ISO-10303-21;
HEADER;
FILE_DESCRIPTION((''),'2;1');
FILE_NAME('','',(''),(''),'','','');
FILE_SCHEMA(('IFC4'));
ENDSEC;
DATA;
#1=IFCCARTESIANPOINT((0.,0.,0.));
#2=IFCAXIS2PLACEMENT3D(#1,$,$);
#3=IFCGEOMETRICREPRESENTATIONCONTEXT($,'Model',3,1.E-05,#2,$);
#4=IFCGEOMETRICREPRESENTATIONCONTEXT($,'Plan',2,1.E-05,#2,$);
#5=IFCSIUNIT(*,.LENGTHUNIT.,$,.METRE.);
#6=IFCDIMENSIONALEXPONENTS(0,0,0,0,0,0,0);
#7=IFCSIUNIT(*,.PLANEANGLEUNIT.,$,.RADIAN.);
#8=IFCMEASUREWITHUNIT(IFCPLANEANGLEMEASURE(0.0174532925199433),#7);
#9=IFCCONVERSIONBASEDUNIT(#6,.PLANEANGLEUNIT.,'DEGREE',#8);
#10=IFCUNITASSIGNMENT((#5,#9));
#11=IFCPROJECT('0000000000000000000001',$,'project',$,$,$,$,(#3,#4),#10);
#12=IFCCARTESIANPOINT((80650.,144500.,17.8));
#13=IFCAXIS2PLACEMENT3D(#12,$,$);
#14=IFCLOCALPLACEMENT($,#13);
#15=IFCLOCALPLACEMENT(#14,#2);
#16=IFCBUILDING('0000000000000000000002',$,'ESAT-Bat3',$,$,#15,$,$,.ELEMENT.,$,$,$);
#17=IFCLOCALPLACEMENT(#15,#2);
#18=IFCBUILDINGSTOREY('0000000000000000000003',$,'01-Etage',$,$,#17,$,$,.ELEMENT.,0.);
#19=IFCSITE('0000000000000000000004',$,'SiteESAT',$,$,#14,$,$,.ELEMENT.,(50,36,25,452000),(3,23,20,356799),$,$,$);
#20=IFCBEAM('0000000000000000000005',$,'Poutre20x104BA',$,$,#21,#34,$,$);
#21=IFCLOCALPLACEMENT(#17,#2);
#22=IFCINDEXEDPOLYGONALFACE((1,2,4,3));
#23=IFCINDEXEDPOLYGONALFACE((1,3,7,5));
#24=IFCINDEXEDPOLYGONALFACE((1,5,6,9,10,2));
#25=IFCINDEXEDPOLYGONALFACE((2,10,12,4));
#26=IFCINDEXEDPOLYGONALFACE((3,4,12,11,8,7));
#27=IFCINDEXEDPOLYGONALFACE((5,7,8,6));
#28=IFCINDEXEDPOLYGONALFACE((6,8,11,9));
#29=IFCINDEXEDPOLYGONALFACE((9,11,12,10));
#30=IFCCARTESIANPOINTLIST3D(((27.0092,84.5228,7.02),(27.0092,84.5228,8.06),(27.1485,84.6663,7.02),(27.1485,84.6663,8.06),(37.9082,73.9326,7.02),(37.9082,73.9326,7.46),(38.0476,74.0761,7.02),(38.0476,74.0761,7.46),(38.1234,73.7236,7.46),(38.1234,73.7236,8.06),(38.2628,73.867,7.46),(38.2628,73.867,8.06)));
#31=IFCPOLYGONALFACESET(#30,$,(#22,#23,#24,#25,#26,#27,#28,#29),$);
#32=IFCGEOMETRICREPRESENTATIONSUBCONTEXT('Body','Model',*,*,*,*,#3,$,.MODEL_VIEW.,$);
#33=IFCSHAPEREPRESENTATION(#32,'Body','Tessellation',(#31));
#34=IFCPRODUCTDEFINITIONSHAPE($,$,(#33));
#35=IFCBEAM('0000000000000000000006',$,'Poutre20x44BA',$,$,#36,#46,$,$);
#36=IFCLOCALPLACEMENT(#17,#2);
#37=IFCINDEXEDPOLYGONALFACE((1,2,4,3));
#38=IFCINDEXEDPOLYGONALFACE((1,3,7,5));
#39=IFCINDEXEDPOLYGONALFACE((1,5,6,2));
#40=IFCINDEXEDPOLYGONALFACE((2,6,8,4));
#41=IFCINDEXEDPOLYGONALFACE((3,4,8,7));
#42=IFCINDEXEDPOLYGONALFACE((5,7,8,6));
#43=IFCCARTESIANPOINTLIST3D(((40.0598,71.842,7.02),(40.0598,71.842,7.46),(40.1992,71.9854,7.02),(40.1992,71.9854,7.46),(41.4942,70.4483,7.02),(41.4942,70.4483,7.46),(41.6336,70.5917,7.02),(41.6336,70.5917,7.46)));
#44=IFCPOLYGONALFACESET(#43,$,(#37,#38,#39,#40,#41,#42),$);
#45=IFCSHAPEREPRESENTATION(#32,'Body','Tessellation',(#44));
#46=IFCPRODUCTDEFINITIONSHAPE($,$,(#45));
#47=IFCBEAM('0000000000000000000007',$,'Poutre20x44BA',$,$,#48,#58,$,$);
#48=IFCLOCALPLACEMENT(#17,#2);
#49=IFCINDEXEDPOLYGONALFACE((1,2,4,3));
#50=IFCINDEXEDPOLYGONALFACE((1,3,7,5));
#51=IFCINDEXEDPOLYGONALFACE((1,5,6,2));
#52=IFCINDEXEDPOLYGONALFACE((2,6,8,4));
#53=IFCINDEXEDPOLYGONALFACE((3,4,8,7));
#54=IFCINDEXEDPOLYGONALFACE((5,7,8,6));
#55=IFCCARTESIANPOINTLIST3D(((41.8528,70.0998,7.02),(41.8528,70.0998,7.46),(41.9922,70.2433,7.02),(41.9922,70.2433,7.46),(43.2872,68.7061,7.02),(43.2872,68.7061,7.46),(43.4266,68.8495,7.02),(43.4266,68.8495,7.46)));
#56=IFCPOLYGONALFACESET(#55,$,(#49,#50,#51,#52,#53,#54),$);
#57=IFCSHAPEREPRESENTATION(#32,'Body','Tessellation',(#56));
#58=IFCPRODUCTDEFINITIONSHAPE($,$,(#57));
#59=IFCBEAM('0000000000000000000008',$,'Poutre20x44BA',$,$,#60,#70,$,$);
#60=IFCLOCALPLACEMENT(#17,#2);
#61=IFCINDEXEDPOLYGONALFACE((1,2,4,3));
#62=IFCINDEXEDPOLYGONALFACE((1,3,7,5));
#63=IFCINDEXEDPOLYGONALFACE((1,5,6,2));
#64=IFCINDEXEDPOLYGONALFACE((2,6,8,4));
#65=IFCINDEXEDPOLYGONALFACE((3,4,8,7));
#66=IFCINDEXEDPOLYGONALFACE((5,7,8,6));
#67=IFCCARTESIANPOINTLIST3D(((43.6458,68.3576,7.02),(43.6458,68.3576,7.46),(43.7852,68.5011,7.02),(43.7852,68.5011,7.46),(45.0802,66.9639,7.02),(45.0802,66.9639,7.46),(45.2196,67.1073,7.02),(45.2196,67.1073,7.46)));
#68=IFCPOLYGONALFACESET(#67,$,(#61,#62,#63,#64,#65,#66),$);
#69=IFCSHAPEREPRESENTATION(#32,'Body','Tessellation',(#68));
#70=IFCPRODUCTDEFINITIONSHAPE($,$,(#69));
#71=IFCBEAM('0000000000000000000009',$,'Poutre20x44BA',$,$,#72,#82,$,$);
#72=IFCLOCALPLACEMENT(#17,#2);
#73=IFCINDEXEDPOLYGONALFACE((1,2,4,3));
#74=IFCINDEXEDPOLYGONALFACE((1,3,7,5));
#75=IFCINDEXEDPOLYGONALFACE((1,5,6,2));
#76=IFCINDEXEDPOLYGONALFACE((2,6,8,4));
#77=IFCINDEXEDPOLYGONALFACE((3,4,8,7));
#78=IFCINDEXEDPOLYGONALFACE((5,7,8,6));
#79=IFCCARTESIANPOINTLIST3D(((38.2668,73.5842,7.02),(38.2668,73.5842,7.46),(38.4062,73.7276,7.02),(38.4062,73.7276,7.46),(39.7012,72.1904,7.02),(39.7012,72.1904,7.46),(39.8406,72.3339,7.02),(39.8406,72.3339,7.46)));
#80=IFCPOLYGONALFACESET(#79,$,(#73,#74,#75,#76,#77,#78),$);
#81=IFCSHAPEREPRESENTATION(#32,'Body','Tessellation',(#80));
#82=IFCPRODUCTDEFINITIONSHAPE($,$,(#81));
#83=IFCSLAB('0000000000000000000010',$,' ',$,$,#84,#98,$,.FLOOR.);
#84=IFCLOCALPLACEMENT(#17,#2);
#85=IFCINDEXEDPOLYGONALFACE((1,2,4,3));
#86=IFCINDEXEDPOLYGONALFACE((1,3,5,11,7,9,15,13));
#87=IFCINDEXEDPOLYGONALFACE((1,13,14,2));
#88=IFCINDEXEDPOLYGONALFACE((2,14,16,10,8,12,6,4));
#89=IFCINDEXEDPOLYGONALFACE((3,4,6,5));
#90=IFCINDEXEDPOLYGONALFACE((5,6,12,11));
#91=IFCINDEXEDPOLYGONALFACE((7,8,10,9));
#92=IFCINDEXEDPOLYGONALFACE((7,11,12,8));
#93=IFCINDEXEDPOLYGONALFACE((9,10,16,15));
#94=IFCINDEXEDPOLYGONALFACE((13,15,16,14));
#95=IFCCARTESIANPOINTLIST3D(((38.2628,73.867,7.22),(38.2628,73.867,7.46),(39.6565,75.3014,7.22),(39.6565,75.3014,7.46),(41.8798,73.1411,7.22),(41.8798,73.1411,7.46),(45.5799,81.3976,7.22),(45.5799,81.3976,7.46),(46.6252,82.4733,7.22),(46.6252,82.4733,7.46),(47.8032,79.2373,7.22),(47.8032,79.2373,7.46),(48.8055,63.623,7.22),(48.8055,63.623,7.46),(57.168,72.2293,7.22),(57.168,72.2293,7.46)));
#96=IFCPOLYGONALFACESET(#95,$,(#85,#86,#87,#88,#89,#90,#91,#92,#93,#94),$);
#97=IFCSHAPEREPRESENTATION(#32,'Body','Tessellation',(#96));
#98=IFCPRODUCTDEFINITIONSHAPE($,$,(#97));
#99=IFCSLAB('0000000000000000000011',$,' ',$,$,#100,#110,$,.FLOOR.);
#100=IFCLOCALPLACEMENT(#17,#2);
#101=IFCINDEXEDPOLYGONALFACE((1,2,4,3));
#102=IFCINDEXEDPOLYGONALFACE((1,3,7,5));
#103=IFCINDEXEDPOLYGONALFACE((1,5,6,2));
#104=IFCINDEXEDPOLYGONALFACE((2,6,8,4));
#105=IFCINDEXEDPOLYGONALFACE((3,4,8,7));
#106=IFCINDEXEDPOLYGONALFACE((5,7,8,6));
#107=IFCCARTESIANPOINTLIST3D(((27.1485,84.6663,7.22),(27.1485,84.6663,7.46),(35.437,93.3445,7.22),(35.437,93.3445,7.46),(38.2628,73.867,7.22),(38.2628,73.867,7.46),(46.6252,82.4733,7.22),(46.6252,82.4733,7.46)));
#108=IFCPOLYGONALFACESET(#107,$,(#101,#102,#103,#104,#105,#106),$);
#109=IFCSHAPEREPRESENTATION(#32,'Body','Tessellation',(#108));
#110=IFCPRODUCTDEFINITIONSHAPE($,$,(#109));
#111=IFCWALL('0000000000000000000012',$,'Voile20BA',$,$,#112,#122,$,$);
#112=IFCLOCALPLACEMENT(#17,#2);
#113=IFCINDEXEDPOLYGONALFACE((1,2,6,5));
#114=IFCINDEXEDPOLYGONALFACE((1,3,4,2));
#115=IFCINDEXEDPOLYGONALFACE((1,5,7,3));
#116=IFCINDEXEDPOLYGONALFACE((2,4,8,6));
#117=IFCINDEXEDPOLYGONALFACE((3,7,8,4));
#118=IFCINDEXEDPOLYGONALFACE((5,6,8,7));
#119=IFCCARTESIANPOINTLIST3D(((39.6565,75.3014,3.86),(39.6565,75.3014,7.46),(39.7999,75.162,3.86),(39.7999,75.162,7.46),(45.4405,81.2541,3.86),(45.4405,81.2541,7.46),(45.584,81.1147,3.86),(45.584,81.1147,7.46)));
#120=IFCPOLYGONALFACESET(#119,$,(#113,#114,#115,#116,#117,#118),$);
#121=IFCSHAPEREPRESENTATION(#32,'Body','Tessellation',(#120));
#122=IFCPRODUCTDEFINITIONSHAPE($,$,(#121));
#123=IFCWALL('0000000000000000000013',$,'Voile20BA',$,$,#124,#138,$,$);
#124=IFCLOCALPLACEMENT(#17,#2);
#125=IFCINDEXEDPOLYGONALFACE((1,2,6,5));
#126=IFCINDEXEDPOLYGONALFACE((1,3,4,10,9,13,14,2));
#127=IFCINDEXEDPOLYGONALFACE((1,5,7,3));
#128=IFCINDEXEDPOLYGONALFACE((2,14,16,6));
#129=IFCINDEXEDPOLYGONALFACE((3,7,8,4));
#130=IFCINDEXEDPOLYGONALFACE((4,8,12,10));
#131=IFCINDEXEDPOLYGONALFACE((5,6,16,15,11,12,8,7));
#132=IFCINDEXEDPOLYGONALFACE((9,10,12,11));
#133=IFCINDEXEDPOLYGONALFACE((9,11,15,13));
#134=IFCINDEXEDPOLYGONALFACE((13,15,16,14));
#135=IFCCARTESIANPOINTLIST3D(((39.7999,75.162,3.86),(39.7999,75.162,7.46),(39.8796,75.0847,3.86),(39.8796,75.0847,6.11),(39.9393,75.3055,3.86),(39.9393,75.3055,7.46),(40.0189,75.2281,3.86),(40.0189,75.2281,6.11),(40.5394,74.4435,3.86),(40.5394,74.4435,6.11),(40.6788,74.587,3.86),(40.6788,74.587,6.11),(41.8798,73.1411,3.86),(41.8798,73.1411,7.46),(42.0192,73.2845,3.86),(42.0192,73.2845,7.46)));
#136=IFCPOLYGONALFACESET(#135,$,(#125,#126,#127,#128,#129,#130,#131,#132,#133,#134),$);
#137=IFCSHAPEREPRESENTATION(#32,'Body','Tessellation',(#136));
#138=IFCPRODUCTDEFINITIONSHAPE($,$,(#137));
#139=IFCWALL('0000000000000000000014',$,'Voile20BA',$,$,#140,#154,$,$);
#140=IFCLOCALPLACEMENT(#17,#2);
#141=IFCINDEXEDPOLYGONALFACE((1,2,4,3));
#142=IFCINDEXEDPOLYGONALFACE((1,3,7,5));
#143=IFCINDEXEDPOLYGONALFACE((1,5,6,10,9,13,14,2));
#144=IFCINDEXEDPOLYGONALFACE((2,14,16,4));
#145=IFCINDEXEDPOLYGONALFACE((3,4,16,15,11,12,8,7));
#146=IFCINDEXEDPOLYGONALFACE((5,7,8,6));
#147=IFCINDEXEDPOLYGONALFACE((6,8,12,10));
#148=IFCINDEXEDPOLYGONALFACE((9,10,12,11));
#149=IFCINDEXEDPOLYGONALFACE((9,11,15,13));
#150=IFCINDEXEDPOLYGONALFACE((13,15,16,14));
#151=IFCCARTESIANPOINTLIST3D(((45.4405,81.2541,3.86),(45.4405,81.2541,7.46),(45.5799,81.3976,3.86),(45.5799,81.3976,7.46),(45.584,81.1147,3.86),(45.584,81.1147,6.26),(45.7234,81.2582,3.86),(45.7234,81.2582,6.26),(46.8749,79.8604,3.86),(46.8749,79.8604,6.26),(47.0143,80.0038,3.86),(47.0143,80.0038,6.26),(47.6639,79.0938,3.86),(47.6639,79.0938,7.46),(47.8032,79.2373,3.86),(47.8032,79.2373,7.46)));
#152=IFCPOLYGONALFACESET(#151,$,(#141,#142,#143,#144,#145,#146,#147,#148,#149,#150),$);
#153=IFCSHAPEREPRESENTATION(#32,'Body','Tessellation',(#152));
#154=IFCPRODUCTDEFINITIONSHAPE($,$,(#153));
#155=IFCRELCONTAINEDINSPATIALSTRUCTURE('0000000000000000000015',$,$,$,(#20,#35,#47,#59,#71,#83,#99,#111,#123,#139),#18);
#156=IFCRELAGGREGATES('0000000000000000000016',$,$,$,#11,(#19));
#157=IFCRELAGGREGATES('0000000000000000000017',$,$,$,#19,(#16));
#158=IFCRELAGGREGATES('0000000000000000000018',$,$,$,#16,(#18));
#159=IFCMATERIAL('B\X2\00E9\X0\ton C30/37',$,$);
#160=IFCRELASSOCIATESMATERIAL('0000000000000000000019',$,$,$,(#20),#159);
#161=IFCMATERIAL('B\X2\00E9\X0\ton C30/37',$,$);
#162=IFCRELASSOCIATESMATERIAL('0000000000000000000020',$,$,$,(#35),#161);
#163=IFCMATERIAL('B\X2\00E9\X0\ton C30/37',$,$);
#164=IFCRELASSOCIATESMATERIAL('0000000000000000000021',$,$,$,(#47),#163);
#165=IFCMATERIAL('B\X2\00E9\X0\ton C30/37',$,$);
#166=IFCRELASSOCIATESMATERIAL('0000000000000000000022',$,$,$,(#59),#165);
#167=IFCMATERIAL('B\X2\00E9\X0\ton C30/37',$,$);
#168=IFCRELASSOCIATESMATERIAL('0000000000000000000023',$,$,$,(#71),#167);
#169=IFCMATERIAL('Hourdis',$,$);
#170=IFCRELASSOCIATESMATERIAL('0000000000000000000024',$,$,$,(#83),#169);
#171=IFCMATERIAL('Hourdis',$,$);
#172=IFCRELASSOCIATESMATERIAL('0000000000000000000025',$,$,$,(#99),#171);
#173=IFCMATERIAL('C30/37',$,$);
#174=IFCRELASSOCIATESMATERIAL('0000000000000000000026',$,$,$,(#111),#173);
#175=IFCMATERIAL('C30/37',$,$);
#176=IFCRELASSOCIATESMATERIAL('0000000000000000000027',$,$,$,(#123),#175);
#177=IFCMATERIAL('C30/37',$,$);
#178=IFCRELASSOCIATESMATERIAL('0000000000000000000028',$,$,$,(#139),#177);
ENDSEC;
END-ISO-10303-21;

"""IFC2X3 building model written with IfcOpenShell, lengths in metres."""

from ifc_helpers import new_model, entity, si_unit, converted_unit, frame, frame_2d, origin, origin_with_axes, place, context, subcontext, project, spatial, polyline, rectangle, outline, extrude, clip, bounded_halfspace, material, element, save


model = new_model("IFC2X3")

# Units and contexts
model_context = context("Model", 3, precision=1e-05, world=origin())
plan_context = context("Plan", 2, precision=1e-05, world=origin())
body_context = subcontext(model_context, "Body", "Model", "MODEL_VIEW")
ifc_project = project(units=[si_unit("LENGTHUNIT", "METRE"), converted_unit("PLANEANGLEUNIT", "DEGREE", entity("IfcPlaneAngleMeasure", 0.0174532925199433), si_unit("PLANEANGLEUNIT", "RADIAN"), dimensions=[0, 0, 0, 0, 0, 0, 0])], contexts=[model_context, plan_context])

# Site, building, storey
site_placement = place(None, frame((80650.0, 144500.0, 17.8)))
site = spatial("IfcSite", under=ifc_project, at=site_placement, Name="SiteESAT", CompositionType="ELEMENT", RefLatitude=(50, 36, 25, 452000), RefLongitude=(3, 23, 20, 356799))
building_placement = place(site_placement, origin())
building = spatial("IfcBuilding", under=site, at=building_placement, Name="ESAT-Bat3", CompositionType="ELEMENT")
storey_placement = place(building_placement, origin())
storey = spatial("IfcBuildingStorey", under=building, at=storey_placement, Name="01-Etage", CompositionType="ELEMENT", Elevation=0.0)

# Beams
ifc_material_1 = material(Name="Béton C30/37")
beam_1_placement = place(storey_placement, frame((38.2628, 73.867, 7.02), z_axis=(0.0, 0.0, 1.0), x_axis=(-0.717196, 0.696872, 0.0)))
element("IfcBeam", 1, at=beam_1_placement, inside=storey, material=ifc_material_1, Name="Poutre20x104BA", context=body_context, shape_type="Clipping", body=[
    clip(extrude(rectangle(XDim=0.2, YDim=1.04, at=frame_2d((0.1, 0.52), x_axis=(1.0, 0.0))), frame((0.0, 0.0, 0.0), z_axis=(1.0, 0.0, 0.0), x_axis=(0.0, 1.0, 0.0)), (0.0, 0.0, 1.0), 15.4968), bounded_halfspace(frame((0.15, 0.1, 0.44), z_axis=(0.0, 0.0, 1.0), x_axis=(1.0, 0.0, 0.0)), True, origin_with_axes(), polyline([(0.0, 0.0), (0.3, 0.0), (0.3, 0.2), (0.0, 0.2), (0.0, 0.0)]))),
])
ifc_material_2 = material(Name="Béton C30/37")
beam_2_placement = place(storey_placement, frame((41.6336, 70.5917, 7.02), z_axis=(0.0, 0.0, 1.0), x_axis=(-0.717196, 0.696872, 0.0)))
element("IfcBeam", 2, at=beam_2_placement, inside=storey, material=ifc_material_2, Name="Poutre20x44BA", context=body_context, shape_type="SweptSolid", body=[
    extrude(rectangle(XDim=0.2, YDim=0.44, at=frame_2d((0.1, 0.22), x_axis=(1.0, 0.0))), frame((0.0, 0.0, 0.0), z_axis=(1.0, 0.0, 0.0), x_axis=(0.0, 1.0, 0.0)), (0.0, 0.0, 1.0), 2.0),
])
ifc_material_3 = material(Name="Béton C30/37")
beam_3_placement = place(storey_placement, frame((43.4266, 68.8495, 7.02), z_axis=(0.0, 0.0, 1.0), x_axis=(-0.717196, 0.696872, 0.0)))
element("IfcBeam", 3, at=beam_3_placement, inside=storey, material=ifc_material_3, Name="Poutre20x44BA", context=body_context, shape_type="SweptSolid", body=[
    extrude(rectangle(XDim=0.2, YDim=0.44, at=frame_2d((0.1, 0.22), x_axis=(1.0, 0.0))), frame((0.0, 0.0, 0.0), z_axis=(1.0, 0.0, 0.0), x_axis=(0.0, 1.0, 0.0)), (0.0, 0.0, 1.0), 2.0),
])
ifc_material_4 = material(Name="Béton C30/37")
beam_4_placement = place(storey_placement, frame((45.2196, 67.1073, 7.02), z_axis=(0.0, 0.0, 1.0), x_axis=(-0.717196, 0.696872, 0.0)))
element("IfcBeam", 4, at=beam_4_placement, inside=storey, material=ifc_material_4, Name="Poutre20x44BA", context=body_context, shape_type="SweptSolid", body=[
    extrude(rectangle(XDim=0.2, YDim=0.44, at=frame_2d((0.1, 0.22), x_axis=(1.0, 0.0))), frame((0.0, 0.0, 0.0), z_axis=(1.0, 0.0, 0.0), x_axis=(0.0, 1.0, 0.0)), (0.0, 0.0, 1.0), 2.0),
])
ifc_material_5 = material(Name="Béton C30/37")
beam_5_placement = place(storey_placement, frame((39.8406, 72.3339, 7.02), z_axis=(0.0, 0.0, 1.0), x_axis=(-0.717196, 0.696872, 0.0)))
element("IfcBeam", 5, at=beam_5_placement, inside=storey, material=ifc_material_5, Name="Poutre20x44BA", context=body_context, shape_type="SweptSolid", body=[
    extrude(rectangle(XDim=0.2, YDim=0.44, at=frame_2d((0.1, 0.22), x_axis=(1.0, 0.0))), frame((0.0, 0.0, 0.0), z_axis=(1.0, 0.0, 0.0), x_axis=(0.0, 1.0, 0.0)), (0.0, 0.0, 1.0), 2.0),
])

# Slabs
ifc_material_6 = material(Name="Hourdis")
slab_1_placement = place(storey_placement, frame((38.2628, 63.623, 7.22)))
element("IfcSlab", 6, at=slab_1_placement, inside=storey, material=ifc_material_6, Name=" ", PredefinedType="FLOOR", context=body_context, shape_type="SweptSolid", body=[
    extrude(outline(polyline([(0.0, 10.244), (10.5428, 0.0), (18.9052, 8.6063), (8.3625, 18.8504), (7.3172, 17.7746), (9.5405, 15.6143), (3.6171, 9.5181), (1.3937, 11.6784), (0.0, 10.244)])), origin_with_axes(), (0.0, 0.0, 1.0), 0.24),
])
ifc_material_7 = material(Name="Hourdis")
slab_2_placement = place(storey_placement, frame((27.1485, 73.867, 7.22)))
element("IfcSlab", 7, at=slab_2_placement, inside=storey, material=ifc_material_7, Name=" ", PredefinedType="FLOOR", context=body_context, shape_type="SweptSolid", body=[
    extrude(outline(polyline([(8.2884, 19.4775), (0.0, 10.7993), (11.1142, 0.0), (19.4767, 8.6063), (8.2884, 19.4775)])), origin_with_axes(), (0.0, 0.0, 1.0), 0.24),
])

# Wall
ifc_material_8 = material(Name="C30/37")
wall_1_placement = place(storey_placement, frame((45.4405, 81.2541, 3.86), z_axis=(0.0, 0.0, 1.0), x_axis=(-0.696872, -0.717196, 0.0)))
element("IfcWall", 8, at=wall_1_placement, inside=storey, material=ifc_material_8, Name="Voile20BA", context=body_context, shape_type="SweptSolid", body=[
    extrude(rectangle(XDim=8.3, YDim=0.2, at=frame_2d((4.15, 0.1), x_axis=(1.0, 0.0))), origin_with_axes(), (0.0, 0.0, 1.0), 3.6),
])

# Walls, openings
ifc_material_9 = material(Name="C30/37")
wall_2_placement = place(storey_placement, frame((39.7999, 75.162, 3.86), z_axis=(0.0, 0.0, 1.0), x_axis=(0.717196, -0.696872, 0.0)))
wall_2 = element("IfcWall", 9, at=wall_2_placement, inside=storey, material=ifc_material_9, Name="Voile20BA", context=body_context, shape_type="SweptSolid", body=[
    extrude(rectangle(XDim=2.9, YDim=0.2, at=frame_2d((1.45, 0.1), x_axis=(1.0, 0.0))), origin_with_axes(), (0.0, 0.0, 1.0), 3.6),
])
opening_1_placement = place(wall_2_placement, frame((0.111, 0.0, 0.0), z_axis=(0.0, 1.0, 0.0), x_axis=(0.0, 0.0, 1.0)))
element("IfcOpeningElement", 10, at=opening_1_placement, cuts=wall_2, ObjectType="Opening", context=body_context, shape_type="SweptSolid", body=[
    extrude(outline(polyline([(0.0, 0.92), (2.25, 0.92), (2.25, 0.0), (0.0, 0.0), (0.0, 0.92)])), origin_with_axes(), (0.0, 0.0, 1.0), 0.2),
])
ifc_material_10 = material(Name="C30/37")
wall_3_placement = place(storey_placement, frame((45.4405, 81.2541, 3.86), z_axis=(0.0, 0.0, 1.0), x_axis=(0.717196, -0.696872, 0.0)))
wall_3 = element("IfcWall", 11, at=wall_3_placement, inside=storey, material=ifc_material_10, Name="Voile20BA", context=body_context, shape_type="SweptSolid", body=[
    extrude(rectangle(XDim=3.1, YDim=0.2, at=frame_2d((1.55, 0.1), x_axis=(1.0, 0.0))), origin_with_axes(), (0.0, 0.0, 1.0), 3.6),
])
opening_2_placement = place(wall_3_placement, frame((2.0, 0.2, 0.0), z_axis=(0.0, -1.0, 0.0), x_axis=(0.0, 0.0, 1.0)))
element("IfcOpeningElement", 12, at=opening_2_placement, cuts=wall_3, ObjectType="Opening", context=body_context, shape_type="SweptSolid", body=[
    extrude(outline(polyline([(0.0, 1.8), (2.4, 1.8), (2.4, 0.0), (0.0, 0.0), (0.0, 1.8)])), origin_with_axes(), (0.0, 0.0, 1.0), 0.2),
])

save(model, "model.ifc")
